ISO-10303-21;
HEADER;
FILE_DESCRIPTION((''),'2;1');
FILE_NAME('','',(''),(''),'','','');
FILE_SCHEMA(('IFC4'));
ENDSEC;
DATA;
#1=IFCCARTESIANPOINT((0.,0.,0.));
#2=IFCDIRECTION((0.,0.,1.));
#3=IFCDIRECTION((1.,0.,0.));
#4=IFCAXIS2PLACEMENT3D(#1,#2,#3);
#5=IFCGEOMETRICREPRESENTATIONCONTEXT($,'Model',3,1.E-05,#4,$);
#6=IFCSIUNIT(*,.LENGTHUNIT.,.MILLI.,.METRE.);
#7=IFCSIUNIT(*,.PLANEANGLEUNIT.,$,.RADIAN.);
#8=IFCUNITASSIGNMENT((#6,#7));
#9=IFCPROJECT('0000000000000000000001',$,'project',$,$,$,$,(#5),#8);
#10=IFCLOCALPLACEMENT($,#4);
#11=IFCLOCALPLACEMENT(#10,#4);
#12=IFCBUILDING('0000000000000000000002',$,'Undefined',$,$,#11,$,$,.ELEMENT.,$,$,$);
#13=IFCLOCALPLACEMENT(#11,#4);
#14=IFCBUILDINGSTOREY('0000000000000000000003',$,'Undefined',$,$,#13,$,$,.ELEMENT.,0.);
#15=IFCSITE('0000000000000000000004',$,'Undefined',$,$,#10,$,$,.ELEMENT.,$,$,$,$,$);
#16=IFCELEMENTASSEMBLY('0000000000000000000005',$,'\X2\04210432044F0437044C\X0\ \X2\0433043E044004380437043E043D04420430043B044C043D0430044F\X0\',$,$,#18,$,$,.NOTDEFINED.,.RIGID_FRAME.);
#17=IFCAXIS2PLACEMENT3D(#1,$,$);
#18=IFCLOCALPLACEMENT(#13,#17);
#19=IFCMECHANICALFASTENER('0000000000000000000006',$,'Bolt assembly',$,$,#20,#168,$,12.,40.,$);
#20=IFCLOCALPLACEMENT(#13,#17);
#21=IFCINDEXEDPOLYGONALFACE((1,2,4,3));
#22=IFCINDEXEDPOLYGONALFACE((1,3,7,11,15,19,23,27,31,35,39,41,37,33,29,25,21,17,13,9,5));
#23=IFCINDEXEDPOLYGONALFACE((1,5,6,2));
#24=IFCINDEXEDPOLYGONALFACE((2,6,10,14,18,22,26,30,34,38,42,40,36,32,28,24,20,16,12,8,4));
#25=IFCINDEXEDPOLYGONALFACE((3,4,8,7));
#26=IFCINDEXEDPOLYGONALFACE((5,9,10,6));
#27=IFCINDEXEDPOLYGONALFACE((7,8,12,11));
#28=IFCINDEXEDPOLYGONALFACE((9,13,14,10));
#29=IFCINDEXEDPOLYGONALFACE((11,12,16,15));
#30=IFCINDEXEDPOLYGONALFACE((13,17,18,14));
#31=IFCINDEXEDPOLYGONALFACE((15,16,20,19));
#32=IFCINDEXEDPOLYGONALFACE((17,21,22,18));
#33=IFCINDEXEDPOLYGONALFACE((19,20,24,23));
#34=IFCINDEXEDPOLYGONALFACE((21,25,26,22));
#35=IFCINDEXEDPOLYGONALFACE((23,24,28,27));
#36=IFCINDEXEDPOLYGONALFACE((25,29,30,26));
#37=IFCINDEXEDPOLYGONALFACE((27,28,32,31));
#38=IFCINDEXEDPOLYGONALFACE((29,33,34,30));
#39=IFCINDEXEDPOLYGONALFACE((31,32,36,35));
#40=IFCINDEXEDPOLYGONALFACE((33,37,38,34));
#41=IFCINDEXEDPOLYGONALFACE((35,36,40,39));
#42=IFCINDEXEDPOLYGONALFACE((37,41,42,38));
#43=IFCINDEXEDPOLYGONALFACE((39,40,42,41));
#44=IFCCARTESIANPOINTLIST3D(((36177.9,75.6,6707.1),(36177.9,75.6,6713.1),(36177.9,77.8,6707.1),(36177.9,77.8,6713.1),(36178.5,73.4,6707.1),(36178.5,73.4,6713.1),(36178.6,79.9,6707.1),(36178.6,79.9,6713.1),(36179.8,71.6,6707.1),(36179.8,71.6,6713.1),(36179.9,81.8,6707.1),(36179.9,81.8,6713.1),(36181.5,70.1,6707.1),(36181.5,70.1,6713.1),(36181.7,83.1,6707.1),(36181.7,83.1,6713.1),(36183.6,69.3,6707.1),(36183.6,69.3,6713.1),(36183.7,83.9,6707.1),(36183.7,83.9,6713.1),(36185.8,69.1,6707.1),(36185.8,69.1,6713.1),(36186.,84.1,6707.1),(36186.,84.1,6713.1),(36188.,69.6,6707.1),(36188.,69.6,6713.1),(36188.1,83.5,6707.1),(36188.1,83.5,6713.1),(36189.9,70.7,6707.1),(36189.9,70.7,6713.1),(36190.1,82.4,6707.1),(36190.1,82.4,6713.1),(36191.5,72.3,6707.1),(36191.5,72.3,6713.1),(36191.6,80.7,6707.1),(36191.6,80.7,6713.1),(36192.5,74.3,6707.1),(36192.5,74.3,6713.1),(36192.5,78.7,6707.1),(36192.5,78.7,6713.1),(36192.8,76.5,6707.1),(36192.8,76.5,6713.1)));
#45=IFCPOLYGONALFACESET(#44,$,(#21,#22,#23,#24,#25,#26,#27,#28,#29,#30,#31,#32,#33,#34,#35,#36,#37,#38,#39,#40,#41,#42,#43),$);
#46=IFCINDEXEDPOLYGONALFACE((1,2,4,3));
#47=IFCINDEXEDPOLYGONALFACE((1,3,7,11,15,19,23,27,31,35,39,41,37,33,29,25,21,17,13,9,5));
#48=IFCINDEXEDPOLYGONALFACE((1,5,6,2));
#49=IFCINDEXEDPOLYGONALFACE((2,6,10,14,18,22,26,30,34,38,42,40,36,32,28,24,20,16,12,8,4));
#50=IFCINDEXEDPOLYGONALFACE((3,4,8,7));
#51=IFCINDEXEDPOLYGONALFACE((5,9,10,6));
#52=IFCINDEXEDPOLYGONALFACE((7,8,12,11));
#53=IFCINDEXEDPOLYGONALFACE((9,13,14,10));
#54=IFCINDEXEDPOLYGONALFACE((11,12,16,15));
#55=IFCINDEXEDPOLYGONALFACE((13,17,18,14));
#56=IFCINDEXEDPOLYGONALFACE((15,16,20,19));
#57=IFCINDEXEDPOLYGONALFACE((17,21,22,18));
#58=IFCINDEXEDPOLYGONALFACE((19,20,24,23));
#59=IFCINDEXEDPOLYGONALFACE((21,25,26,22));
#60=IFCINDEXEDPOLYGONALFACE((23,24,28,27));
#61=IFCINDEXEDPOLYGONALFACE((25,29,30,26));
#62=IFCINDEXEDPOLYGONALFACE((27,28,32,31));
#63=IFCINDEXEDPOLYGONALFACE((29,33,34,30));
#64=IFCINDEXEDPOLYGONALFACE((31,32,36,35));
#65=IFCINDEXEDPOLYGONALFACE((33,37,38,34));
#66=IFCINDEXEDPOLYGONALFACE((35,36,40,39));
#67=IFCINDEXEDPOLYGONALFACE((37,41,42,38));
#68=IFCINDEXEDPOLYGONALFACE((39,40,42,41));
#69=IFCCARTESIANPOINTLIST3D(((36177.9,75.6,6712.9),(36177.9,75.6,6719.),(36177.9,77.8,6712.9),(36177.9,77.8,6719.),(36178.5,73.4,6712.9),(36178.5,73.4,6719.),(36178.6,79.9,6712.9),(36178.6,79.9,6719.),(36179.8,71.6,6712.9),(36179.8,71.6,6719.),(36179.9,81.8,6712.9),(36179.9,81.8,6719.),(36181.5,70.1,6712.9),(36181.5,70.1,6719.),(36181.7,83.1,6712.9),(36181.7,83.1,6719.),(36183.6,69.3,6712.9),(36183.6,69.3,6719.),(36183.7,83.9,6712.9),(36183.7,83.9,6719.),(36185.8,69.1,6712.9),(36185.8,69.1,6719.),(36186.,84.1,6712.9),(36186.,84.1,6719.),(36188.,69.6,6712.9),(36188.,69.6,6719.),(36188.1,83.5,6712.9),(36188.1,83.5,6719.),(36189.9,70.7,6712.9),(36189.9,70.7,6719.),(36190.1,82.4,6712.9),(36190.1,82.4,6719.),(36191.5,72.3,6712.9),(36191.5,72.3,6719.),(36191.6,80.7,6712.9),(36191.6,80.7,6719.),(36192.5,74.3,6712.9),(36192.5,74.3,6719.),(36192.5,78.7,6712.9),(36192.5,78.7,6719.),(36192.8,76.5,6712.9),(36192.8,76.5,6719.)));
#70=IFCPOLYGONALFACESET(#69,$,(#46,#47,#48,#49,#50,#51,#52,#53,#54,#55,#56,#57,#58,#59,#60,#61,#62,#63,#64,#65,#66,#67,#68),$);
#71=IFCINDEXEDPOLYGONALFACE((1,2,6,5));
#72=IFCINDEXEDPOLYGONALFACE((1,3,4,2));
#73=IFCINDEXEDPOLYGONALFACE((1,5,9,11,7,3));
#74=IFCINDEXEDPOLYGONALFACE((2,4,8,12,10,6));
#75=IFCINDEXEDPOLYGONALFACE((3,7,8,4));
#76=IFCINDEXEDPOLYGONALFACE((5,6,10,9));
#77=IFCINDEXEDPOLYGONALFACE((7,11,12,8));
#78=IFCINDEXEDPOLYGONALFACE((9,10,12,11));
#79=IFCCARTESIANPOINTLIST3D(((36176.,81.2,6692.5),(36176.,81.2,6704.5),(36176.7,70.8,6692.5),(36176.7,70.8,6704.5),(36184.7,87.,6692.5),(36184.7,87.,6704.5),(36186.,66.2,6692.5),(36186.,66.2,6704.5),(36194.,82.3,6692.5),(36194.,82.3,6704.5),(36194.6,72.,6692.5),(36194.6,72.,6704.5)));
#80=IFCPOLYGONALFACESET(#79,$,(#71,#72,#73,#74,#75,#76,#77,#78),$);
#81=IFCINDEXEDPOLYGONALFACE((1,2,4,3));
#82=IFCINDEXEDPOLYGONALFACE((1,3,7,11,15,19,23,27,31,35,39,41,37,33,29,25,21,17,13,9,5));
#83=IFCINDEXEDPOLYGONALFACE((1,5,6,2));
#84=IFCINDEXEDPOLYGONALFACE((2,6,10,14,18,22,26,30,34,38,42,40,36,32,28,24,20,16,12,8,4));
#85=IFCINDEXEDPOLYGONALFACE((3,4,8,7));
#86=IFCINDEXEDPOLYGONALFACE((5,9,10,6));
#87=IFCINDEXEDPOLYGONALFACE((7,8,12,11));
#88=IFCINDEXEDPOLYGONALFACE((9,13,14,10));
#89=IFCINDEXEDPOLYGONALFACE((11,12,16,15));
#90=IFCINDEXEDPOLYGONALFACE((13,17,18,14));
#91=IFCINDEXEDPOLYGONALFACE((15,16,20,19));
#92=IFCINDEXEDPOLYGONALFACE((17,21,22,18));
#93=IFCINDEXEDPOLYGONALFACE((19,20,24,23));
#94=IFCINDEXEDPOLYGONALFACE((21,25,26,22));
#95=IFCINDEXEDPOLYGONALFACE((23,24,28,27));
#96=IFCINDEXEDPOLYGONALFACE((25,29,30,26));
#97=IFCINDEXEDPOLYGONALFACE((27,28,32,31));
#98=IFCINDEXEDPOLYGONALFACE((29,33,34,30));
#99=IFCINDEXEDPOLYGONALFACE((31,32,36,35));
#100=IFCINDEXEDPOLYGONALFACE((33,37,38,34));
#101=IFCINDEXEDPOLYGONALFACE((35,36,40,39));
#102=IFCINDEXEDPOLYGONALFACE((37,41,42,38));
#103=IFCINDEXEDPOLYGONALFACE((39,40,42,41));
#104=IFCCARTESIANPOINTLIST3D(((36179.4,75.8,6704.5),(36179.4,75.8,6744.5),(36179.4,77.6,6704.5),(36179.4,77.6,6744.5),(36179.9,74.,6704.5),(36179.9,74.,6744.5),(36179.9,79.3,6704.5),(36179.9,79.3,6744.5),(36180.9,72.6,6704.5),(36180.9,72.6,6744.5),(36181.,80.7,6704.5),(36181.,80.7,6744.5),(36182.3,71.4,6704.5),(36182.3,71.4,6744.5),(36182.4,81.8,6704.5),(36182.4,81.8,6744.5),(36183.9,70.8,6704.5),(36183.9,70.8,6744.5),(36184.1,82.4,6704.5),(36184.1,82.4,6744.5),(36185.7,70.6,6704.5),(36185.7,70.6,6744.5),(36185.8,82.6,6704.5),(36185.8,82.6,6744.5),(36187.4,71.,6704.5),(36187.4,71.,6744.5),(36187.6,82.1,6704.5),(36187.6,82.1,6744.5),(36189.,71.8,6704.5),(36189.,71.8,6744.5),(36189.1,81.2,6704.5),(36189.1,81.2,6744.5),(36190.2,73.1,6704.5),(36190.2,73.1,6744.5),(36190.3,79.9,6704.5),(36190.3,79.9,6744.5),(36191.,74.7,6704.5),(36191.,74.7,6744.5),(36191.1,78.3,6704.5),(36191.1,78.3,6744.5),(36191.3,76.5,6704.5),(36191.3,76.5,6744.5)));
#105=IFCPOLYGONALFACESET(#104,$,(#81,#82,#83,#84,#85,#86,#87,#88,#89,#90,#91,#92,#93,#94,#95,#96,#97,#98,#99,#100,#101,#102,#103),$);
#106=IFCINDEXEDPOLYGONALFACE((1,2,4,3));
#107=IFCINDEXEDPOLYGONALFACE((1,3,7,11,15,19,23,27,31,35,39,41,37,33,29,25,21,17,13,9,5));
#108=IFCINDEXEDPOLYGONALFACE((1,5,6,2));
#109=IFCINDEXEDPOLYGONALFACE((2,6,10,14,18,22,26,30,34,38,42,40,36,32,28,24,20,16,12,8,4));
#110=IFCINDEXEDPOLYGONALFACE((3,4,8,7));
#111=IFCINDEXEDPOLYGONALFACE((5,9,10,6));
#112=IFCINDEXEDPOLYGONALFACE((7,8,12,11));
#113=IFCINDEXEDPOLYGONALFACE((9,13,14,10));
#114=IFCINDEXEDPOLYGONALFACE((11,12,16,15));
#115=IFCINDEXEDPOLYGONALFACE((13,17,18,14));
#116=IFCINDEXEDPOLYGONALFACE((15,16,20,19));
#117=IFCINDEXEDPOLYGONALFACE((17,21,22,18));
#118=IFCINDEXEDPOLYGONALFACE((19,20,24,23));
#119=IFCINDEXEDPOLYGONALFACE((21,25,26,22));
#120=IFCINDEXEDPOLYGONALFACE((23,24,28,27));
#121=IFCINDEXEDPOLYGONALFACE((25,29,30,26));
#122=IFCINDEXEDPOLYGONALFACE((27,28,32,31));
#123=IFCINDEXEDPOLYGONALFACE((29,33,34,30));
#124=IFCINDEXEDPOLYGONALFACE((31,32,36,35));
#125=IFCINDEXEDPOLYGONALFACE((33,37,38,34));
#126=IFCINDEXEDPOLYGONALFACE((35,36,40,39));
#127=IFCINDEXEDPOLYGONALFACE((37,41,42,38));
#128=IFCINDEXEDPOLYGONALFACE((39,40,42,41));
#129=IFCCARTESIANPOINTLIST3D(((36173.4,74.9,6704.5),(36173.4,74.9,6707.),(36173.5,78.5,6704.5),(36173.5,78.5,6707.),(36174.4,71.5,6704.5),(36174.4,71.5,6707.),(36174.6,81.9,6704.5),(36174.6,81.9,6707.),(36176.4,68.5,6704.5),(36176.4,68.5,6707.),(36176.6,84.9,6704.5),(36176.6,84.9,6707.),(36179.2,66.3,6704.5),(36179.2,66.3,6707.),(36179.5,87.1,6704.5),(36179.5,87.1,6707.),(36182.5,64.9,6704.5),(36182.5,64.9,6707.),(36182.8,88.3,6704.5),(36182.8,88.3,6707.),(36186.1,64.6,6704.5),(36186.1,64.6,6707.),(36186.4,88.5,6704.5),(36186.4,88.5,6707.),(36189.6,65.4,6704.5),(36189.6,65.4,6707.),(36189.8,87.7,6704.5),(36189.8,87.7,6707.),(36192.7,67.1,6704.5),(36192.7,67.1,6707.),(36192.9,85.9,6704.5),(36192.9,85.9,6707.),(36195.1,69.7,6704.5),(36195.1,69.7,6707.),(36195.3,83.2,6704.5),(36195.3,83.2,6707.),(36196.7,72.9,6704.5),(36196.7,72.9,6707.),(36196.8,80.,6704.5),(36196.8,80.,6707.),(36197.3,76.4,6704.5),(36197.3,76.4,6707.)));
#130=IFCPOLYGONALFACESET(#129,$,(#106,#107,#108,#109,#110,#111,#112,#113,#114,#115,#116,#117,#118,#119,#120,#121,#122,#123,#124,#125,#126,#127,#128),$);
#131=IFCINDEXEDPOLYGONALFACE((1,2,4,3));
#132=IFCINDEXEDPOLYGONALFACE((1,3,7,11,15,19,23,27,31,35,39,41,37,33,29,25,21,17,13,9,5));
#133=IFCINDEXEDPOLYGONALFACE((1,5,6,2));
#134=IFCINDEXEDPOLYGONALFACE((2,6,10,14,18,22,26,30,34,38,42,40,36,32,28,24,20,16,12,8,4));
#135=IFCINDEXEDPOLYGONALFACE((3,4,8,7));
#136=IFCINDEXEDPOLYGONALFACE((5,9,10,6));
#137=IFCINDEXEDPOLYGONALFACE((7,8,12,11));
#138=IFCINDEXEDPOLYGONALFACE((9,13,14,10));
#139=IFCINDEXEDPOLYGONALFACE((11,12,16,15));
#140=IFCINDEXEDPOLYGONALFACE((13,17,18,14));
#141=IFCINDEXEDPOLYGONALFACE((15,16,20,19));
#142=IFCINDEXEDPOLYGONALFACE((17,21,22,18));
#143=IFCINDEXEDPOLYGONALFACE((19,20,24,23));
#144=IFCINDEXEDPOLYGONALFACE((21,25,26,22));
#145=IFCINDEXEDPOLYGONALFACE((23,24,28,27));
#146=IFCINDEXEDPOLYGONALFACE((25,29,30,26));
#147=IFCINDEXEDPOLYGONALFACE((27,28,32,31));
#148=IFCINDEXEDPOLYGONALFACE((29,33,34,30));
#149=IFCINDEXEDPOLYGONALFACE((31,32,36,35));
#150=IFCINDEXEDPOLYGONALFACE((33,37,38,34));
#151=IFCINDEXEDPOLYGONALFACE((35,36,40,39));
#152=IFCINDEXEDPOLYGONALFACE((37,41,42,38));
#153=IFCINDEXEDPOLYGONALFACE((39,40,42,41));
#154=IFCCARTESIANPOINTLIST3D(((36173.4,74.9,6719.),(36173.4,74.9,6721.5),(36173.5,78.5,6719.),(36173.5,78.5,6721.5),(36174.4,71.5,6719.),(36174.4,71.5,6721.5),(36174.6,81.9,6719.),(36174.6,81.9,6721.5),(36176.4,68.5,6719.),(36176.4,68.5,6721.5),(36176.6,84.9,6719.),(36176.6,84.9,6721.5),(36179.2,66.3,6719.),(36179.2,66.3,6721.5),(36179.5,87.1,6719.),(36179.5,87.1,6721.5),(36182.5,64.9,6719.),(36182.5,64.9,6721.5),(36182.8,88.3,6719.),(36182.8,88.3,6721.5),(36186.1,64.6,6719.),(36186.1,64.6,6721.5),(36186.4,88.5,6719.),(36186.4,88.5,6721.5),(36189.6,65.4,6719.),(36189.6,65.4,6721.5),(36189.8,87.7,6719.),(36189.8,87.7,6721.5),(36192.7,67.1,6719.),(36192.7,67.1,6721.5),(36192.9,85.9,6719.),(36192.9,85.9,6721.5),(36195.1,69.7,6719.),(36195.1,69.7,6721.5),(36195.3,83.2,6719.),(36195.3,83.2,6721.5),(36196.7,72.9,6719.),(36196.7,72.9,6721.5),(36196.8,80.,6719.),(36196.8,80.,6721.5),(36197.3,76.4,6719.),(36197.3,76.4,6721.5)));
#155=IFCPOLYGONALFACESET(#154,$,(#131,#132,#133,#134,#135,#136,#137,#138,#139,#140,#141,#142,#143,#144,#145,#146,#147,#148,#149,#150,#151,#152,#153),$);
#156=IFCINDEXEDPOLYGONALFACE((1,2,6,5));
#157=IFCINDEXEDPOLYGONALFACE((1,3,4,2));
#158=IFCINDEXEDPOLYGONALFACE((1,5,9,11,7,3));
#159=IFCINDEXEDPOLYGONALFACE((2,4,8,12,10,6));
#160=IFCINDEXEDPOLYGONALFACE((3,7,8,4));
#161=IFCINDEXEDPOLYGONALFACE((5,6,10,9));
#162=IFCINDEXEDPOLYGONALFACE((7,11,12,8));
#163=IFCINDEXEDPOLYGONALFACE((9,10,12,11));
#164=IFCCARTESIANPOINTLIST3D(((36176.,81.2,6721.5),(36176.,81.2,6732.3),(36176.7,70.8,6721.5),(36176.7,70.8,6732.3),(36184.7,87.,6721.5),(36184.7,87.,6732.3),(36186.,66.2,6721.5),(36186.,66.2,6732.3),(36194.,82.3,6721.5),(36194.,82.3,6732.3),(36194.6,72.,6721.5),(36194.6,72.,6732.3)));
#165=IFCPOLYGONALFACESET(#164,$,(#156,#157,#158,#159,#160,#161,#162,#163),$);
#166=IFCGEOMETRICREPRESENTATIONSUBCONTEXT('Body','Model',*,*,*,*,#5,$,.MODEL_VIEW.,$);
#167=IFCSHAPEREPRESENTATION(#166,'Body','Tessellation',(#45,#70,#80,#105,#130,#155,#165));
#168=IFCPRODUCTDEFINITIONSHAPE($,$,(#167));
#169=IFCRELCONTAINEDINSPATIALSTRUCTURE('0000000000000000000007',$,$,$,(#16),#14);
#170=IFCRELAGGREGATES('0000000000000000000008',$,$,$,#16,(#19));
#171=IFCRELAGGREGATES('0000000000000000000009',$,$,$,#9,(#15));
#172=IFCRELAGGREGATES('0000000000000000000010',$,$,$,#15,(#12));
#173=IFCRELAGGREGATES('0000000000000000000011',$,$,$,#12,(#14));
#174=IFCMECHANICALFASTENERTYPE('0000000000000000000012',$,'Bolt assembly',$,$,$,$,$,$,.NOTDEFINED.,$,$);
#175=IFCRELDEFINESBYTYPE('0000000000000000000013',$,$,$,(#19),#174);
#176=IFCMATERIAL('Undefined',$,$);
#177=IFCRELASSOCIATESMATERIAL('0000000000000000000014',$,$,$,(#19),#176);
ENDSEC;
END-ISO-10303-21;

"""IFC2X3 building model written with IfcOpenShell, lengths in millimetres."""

from ifc_helpers import new_model, si_unit, frame, origin_with_axes, origin_2d_with_axis, place, context, subcontext, project, spatial, polyline, circle, outline, extrude, source, transform, mapped, material, type_object, element, aggregate, save


model = new_model("IFC2X3")

# Units and contexts
model_context = context("Model", 3, precision=1e-05, world=origin_with_axes())
body_context = subcontext(model_context, "Body", "Model", "MODEL_VIEW")
ifc_project = project(units=[si_unit("LENGTHUNIT", "METRE", prefix="MILLI"), si_unit("PLANEANGLEUNIT", "RADIAN")], contexts=[model_context])

# Site, building, storey
site_placement = place(None, origin_with_axes())
site = spatial("IfcSite", under=ifc_project, at=site_placement, Name="Undefined", CompositionType="ELEMENT")
building_placement = place(site_placement, origin_with_axes())
building = spatial("IfcBuilding", under=site, at=building_placement, Name="Undefined", CompositionType="ELEMENT")
storey_placement = place(building_placement, origin_with_axes())
storey = spatial("IfcBuildingStorey", under=building, at=storey_placement, Name="Undefined", CompositionType="ELEMENT", Elevation=0.0)

# Element assembly
assembly_1_placement = place(storey_placement, origin_with_axes())
assembly_1 = element("IfcElementAssembly", 1, at=assembly_1_placement, inside=storey, Name="Связь горизонтальная", AssemblyPlace="NOTDEFINED", PredefinedType="RIGID_FRAME")

# Mechanical fastener
ifc_material_1 = material(Name="Undefined")
mechanical_fastener_type = type_object("IfcMechanicalFastenerType", Name="Bolt assembly")
shared_shape_1 = source(origin_with_axes(), body_context, "Body", "SweptSolid", [
    extrude(circle(Radius=7.5, at=origin_2d_with_axis()), frame((0.0, 0.1, 0.0), z_axis=(0.0, 1.0, 0.0), x_axis=(1.0, 0.0, 0.0)), (0.0, 0.0, 1.0), 6.0),
    extrude(circle(Radius=7.5, at=origin_2d_with_axis()), frame((0.0, 5.9, 0.0), z_axis=(0.0, 1.0, 0.0), x_axis=(1.0, 0.0, 0.0)), (0.0, 0.0, 1.0), 6.1),
    extrude(outline(polyline([(10.4, 0.0), (5.2, 9.0), (-5.2, 9.0), (-10.4, 0.0), (-5.2, -9.0), (5.2, -9.0), (10.4, 0.0)])), frame((0.0, -14.5, 0.0), z_axis=(0.0, 1.0, 0.0), x_axis=(1.0, 0.0, 0.0)), (0.0, 0.0, 1.0), 12.0),
    extrude(circle(Radius=6.0, at=origin_2d_with_axis()), frame((0.0, -2.5, 0.0), z_axis=(0.0, 1.0, 0.0), x_axis=(1.0, 0.0, 0.0)), (0.0, 0.0, 1.0), 40.0),
    extrude(circle(Radius=12.0, at=origin_2d_with_axis()), frame((0.0, -2.5, 0.0), z_axis=(0.0, 1.0, 0.0), x_axis=(1.0, 0.0, 0.0)), (0.0, 0.0, 1.0), 2.5),
    extrude(circle(Radius=12.0, at=origin_2d_with_axis()), frame((0.0, 12.0, 0.0), z_axis=(0.0, 1.0, 0.0), x_axis=(1.0, 0.0, 0.0)), (0.0, 0.0, 1.0), 2.5),
    extrude(outline(polyline([(10.4, 0.0), (5.2, 9.0), (-5.2, 9.0), (-10.4, 0.0), (-5.2, -9.0), (5.2, -9.0), (10.4, 0.0)])), frame((0.0, 14.5, 0.0), z_axis=(0.0, 1.0, 0.0), x_axis=(1.0, 0.0, 0.0)), (0.0, 0.0, 1.0), 10.8),
])
mechanical_fastener_1_placement = place(assembly_1_placement, frame((36185.3, 76.6, 6707.0), z_axis=(0.552695, -0.833383, 0.0), x_axis=(0.833383, 0.552695, 0.0)))
mechanical_fastener_1 = element("IfcMechanicalFastener", 2, at=mechanical_fastener_1_placement, type_object=mechanical_fastener_type, material=ifc_material_1, Name="Bolt assembly", NominalDiameter=12.0, NominalLength=40.0, context=body_context, shape_type="MappedRepresentation", body=[
    mapped(shared_shape_1, transform((0.0, 0.0, 0.0))),
])
aggregate(assembly_1, [mechanical_fastener_1])

save(model, "model.ifc")
